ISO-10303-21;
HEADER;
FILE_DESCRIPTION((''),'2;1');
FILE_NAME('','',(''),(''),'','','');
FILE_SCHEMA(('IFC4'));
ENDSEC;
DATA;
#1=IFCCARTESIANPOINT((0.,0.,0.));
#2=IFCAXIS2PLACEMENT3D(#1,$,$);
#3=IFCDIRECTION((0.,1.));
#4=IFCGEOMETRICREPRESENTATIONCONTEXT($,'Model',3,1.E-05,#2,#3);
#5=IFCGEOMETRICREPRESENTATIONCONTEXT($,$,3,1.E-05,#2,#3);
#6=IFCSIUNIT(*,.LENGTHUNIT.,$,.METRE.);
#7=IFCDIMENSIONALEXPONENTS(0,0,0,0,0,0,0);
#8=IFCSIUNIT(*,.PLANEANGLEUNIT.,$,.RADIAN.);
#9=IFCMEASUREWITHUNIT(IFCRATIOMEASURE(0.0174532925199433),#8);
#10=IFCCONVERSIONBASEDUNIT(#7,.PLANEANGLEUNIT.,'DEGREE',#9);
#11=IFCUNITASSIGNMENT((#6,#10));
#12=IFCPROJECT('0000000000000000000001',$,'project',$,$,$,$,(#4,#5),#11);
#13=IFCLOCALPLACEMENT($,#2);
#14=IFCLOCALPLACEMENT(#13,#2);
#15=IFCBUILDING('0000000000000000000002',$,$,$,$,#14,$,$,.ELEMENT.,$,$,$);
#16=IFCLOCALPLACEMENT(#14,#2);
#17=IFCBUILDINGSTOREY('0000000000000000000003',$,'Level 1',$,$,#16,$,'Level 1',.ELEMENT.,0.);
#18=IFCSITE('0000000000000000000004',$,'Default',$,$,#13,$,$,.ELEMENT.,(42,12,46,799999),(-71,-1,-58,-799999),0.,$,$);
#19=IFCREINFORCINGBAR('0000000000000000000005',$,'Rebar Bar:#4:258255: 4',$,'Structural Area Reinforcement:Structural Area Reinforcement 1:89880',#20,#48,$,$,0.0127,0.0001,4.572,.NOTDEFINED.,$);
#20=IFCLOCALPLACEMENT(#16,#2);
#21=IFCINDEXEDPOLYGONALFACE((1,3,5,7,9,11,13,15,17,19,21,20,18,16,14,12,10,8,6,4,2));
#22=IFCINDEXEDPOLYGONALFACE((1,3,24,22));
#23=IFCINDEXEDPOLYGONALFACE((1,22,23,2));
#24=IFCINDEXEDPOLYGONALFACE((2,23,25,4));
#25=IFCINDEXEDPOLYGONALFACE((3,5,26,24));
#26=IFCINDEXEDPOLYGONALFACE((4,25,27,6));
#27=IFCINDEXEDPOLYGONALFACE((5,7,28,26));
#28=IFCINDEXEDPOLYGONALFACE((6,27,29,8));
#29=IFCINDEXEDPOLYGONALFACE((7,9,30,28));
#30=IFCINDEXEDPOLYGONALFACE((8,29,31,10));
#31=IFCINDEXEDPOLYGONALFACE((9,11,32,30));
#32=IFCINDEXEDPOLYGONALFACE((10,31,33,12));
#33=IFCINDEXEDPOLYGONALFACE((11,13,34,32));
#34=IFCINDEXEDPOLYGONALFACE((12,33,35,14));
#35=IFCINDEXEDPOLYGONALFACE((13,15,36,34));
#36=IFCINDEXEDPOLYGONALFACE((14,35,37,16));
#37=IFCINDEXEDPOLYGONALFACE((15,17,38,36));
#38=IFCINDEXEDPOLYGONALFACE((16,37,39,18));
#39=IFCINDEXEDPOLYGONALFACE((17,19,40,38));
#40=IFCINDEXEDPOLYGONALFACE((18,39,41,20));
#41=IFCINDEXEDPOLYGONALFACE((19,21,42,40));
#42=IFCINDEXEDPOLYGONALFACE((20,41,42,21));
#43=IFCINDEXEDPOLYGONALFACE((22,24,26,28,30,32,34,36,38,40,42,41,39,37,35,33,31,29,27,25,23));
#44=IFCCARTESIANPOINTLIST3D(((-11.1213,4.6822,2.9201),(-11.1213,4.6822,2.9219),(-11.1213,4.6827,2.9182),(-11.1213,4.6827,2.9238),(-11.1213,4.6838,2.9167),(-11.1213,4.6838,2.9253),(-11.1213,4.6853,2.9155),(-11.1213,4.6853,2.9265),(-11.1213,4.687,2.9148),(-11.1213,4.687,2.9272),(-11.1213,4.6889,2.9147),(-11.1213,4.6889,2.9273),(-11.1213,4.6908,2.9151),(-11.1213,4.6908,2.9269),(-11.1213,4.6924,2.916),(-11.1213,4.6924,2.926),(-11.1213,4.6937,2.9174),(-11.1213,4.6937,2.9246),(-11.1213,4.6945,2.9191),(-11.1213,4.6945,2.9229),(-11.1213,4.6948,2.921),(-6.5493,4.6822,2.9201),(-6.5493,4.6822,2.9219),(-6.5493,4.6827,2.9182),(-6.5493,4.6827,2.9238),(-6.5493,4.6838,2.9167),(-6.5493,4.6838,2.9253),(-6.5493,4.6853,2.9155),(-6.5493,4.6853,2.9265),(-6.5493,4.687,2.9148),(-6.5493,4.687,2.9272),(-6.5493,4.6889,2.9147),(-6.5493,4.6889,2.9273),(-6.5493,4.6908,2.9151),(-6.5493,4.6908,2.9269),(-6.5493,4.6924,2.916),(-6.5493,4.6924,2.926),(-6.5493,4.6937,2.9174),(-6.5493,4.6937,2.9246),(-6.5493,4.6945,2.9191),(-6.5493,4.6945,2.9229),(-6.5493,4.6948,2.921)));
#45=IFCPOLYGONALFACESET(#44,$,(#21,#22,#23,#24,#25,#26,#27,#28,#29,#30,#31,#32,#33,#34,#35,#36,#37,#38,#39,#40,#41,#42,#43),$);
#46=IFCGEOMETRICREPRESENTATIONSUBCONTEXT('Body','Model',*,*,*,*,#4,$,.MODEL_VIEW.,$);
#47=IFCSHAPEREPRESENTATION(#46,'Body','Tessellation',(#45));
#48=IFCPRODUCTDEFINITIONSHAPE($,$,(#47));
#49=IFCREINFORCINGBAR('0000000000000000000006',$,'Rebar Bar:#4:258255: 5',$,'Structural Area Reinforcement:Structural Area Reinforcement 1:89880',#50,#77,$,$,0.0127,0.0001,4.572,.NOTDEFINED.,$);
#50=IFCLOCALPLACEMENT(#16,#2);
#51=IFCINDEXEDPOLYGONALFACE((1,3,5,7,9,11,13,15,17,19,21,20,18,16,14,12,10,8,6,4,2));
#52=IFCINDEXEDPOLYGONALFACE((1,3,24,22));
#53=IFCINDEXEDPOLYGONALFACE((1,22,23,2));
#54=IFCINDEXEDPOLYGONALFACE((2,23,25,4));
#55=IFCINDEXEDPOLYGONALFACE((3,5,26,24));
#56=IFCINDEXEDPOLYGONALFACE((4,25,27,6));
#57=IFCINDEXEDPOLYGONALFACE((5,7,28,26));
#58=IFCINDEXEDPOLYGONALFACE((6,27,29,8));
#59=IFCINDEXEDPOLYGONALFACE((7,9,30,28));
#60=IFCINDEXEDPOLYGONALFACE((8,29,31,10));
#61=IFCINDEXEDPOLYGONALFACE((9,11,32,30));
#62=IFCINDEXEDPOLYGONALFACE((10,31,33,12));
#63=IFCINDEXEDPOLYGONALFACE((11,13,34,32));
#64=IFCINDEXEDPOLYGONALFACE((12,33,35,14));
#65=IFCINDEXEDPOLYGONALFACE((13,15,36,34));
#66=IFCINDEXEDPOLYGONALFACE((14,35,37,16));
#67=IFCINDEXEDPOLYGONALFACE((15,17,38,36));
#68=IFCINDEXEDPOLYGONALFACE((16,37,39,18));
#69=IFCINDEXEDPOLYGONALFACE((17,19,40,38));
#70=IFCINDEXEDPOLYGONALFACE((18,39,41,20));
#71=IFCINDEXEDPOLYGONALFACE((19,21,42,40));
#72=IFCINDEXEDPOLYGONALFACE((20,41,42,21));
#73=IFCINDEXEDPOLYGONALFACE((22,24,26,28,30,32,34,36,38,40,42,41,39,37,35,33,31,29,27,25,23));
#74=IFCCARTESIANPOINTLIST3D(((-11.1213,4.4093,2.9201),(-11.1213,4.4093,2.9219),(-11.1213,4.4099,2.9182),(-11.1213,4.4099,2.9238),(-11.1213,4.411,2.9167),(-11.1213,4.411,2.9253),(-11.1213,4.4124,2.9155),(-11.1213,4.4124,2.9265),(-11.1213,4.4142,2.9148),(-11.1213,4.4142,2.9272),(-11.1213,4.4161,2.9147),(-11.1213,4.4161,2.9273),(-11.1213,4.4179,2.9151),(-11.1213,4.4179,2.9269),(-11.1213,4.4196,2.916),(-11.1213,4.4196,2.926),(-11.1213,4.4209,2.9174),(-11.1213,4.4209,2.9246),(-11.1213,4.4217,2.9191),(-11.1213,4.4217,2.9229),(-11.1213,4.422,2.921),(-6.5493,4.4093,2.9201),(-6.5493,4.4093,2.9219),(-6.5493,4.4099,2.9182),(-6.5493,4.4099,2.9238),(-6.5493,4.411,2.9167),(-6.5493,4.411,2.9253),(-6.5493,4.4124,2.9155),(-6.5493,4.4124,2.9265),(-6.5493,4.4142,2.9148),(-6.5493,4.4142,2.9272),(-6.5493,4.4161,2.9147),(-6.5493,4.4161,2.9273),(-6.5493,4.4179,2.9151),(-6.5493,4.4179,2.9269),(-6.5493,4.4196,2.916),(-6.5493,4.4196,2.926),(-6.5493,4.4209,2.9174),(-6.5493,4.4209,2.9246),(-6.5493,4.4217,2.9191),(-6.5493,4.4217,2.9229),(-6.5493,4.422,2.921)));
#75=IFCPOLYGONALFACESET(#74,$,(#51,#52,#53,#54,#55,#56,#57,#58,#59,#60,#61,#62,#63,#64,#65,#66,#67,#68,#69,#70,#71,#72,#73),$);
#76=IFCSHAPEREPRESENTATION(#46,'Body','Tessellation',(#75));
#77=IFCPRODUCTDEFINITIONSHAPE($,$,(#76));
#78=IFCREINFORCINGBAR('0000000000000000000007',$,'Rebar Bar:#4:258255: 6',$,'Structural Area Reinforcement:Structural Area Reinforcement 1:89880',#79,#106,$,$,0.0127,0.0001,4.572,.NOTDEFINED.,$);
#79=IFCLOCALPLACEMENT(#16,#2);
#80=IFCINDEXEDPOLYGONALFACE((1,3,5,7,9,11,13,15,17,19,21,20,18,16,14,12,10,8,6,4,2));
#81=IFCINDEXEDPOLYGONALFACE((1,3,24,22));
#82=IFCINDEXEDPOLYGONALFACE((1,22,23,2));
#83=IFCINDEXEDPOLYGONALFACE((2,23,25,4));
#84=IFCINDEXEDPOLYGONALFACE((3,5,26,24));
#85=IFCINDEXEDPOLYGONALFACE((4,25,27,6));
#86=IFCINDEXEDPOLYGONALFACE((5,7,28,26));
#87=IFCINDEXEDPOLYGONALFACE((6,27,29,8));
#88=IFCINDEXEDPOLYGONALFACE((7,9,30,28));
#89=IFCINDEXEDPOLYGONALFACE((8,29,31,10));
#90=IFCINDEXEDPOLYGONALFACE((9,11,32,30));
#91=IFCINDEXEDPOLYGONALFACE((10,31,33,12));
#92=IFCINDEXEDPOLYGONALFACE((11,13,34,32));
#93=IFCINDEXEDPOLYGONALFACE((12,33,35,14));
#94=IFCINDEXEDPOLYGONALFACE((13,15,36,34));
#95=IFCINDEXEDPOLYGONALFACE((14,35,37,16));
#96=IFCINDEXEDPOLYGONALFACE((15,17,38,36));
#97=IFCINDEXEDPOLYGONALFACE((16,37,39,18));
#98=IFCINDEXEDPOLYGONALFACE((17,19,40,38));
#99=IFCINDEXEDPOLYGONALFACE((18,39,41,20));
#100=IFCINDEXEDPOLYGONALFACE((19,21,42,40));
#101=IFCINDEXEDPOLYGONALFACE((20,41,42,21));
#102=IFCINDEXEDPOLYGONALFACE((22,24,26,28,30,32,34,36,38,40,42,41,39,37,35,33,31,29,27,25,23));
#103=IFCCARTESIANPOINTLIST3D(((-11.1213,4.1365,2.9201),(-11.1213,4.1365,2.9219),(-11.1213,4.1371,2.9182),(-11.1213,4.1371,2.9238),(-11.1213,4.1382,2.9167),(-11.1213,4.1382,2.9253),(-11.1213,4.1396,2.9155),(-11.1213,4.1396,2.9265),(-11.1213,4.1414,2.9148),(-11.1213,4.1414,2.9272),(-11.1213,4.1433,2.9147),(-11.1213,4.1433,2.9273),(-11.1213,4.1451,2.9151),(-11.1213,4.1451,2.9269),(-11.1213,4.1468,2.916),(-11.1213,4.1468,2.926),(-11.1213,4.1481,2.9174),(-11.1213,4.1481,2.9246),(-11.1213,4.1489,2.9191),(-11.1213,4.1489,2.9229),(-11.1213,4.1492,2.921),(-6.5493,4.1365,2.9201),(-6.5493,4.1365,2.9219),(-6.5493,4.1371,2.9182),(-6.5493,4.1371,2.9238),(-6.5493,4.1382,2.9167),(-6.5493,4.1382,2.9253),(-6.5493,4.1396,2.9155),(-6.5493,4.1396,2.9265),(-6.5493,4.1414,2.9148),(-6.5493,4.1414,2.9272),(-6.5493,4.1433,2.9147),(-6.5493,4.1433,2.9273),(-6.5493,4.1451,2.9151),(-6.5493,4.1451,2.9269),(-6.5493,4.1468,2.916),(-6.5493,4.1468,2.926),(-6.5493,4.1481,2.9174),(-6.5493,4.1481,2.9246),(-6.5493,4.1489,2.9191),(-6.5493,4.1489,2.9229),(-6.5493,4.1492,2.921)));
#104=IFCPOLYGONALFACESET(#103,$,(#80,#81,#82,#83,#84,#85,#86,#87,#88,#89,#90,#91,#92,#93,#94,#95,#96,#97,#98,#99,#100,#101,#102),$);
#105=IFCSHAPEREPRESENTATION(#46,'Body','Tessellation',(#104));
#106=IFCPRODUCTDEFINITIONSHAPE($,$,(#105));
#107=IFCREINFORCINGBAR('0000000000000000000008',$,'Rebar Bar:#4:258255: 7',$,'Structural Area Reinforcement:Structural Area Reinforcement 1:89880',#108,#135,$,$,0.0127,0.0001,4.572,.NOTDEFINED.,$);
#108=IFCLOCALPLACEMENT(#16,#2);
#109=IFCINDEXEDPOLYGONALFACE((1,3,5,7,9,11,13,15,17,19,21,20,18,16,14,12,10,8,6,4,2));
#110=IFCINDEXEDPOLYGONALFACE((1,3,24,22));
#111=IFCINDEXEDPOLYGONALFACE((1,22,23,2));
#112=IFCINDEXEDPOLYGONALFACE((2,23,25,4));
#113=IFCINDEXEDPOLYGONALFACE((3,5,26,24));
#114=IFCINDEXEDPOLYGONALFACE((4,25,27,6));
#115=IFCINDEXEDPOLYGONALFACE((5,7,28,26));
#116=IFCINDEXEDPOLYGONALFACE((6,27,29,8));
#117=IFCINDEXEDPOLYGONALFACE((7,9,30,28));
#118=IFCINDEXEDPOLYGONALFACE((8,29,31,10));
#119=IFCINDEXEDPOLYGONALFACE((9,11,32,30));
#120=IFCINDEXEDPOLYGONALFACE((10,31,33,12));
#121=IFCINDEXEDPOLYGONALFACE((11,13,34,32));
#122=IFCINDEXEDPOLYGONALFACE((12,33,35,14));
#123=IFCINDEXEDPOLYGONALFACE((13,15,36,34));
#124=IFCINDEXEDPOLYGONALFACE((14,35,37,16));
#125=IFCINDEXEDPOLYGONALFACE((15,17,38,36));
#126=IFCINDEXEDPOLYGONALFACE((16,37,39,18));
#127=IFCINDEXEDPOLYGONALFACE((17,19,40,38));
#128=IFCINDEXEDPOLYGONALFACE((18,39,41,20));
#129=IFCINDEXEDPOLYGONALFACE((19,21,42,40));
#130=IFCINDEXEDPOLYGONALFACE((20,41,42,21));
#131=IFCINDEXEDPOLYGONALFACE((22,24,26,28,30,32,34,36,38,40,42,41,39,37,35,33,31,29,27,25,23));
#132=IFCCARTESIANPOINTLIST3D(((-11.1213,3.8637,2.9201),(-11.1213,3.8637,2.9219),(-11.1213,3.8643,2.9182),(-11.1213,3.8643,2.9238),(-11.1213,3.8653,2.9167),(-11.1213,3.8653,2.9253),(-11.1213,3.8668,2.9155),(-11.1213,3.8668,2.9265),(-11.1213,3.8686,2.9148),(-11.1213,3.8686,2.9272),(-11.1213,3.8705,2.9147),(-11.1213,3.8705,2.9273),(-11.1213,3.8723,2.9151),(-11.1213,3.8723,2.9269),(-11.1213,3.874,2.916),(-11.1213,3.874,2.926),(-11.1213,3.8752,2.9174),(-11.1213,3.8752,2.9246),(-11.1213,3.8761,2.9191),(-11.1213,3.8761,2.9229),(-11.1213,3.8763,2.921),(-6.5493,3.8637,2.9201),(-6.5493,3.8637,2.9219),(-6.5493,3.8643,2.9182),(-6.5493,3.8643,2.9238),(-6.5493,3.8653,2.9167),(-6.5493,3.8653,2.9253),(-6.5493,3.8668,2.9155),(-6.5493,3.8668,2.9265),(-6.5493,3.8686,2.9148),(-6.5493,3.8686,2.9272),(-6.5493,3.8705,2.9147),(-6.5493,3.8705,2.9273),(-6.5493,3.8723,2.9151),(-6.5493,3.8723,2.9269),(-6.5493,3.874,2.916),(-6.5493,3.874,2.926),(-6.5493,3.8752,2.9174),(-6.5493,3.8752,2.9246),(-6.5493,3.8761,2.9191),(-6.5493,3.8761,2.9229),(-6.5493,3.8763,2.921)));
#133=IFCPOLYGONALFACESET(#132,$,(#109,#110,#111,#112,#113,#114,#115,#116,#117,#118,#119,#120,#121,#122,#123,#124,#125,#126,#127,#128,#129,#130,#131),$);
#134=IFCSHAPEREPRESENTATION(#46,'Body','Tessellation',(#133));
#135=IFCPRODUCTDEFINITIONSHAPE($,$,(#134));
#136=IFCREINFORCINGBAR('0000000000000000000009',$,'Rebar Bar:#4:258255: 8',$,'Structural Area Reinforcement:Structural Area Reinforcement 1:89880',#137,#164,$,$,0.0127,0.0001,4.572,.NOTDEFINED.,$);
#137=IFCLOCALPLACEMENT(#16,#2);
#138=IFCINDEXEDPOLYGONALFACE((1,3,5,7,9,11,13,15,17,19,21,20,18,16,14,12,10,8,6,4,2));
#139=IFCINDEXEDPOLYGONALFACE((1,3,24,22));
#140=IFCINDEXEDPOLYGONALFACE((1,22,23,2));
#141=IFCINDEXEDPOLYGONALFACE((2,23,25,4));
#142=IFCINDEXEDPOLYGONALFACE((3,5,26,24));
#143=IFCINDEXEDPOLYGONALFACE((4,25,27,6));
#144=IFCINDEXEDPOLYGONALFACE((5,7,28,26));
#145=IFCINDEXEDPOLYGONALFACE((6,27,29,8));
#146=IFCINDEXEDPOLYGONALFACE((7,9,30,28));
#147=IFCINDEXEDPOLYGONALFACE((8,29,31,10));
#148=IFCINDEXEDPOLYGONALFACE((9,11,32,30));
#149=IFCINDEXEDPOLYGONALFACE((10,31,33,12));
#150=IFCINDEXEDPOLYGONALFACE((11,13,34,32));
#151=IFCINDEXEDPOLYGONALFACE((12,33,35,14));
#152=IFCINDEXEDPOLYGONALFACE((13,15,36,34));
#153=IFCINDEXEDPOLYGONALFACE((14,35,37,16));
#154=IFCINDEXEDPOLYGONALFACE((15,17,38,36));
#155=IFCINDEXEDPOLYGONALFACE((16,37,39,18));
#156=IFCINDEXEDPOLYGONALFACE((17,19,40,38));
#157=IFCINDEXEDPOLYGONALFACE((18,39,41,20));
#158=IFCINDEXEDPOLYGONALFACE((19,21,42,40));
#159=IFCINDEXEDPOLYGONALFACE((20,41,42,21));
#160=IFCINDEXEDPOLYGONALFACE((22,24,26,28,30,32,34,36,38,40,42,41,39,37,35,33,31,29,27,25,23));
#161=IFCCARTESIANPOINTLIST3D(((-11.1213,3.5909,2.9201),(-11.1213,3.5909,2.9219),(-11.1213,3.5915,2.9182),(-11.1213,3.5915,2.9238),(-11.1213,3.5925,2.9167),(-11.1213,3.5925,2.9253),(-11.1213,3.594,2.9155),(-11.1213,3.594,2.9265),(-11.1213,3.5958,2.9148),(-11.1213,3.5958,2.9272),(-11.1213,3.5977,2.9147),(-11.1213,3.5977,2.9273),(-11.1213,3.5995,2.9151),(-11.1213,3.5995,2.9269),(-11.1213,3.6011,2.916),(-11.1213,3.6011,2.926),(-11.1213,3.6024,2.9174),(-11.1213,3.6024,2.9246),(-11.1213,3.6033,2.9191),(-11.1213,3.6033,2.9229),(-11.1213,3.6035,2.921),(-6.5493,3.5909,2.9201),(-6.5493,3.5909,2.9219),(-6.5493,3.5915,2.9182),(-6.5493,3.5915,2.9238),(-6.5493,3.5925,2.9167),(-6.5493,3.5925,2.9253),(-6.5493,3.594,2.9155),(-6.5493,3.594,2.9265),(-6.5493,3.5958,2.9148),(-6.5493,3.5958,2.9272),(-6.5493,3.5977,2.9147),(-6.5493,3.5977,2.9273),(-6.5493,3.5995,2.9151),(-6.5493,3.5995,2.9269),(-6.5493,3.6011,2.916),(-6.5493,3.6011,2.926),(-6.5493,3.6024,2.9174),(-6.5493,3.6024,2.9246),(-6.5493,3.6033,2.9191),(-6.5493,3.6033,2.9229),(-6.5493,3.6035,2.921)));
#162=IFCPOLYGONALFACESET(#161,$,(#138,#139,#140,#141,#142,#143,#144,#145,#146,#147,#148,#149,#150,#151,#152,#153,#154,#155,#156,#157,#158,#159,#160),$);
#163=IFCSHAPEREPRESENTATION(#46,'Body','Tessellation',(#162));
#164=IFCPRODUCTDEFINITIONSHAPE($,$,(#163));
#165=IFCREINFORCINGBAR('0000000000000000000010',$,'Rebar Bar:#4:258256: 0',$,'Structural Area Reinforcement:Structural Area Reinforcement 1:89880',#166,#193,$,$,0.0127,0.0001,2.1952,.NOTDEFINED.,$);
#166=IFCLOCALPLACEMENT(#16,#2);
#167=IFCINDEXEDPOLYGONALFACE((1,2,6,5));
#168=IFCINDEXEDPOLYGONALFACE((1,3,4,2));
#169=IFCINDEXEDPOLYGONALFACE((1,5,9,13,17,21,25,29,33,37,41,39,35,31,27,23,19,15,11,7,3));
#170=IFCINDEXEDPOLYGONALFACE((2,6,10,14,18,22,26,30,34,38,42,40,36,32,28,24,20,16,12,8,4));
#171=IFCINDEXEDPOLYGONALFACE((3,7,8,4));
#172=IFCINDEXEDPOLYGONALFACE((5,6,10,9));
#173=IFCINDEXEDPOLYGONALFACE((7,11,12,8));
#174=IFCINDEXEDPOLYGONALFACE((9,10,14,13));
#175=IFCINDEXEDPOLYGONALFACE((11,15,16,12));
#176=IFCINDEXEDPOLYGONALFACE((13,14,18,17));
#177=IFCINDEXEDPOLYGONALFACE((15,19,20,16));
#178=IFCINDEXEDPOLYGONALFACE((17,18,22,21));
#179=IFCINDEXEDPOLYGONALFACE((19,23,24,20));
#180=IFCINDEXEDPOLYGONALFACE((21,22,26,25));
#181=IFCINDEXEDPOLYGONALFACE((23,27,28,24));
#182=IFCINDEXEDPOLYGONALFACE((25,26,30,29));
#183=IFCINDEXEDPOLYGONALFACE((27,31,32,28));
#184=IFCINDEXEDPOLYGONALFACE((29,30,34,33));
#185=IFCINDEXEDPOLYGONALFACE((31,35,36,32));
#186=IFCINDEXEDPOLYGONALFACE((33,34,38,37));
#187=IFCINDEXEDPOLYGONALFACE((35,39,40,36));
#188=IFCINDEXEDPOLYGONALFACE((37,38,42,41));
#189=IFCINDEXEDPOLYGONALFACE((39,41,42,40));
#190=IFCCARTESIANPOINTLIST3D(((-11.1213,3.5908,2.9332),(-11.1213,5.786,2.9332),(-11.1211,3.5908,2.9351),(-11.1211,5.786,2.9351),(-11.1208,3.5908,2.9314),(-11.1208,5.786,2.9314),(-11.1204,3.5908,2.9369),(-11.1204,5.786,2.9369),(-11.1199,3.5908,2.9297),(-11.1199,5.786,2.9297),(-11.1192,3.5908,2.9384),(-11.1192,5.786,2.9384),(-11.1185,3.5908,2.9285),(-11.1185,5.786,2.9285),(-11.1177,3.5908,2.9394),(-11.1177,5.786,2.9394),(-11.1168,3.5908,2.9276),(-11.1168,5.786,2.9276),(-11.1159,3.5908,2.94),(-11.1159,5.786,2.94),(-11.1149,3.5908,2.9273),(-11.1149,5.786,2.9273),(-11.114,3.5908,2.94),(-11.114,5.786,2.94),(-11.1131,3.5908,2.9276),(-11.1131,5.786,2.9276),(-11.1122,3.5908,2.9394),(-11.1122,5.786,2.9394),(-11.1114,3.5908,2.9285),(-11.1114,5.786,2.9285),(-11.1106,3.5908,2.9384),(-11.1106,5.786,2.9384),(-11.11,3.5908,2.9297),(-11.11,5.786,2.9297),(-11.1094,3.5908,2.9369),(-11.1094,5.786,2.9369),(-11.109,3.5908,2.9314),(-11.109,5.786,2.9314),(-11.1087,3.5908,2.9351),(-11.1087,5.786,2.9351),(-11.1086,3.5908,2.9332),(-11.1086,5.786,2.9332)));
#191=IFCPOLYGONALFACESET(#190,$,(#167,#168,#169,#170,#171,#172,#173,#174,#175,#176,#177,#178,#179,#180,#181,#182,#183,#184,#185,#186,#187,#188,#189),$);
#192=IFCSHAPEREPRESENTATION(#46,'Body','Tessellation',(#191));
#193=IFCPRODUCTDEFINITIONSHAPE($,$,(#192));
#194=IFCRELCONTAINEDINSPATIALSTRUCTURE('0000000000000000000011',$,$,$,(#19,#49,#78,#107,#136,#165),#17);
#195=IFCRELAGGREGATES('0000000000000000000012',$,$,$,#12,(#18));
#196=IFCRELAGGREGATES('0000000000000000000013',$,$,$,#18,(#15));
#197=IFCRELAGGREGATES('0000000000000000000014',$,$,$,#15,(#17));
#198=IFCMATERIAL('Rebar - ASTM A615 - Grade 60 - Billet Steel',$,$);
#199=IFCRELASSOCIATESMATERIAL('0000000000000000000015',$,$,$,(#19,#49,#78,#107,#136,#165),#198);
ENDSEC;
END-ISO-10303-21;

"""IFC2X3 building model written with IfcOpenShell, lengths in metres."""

from ifc_helpers import new_model, entity, si_unit, converted_unit, direction, origin, place, context, subcontext, project, spatial, material, element, save


model = new_model("IFC2X3")

# Units and contexts
model_context = context("Model", 3, precision=1e-05, world=origin(), true_north=direction((0.0, 1.0)))
context_of_model = context(None, 3, precision=1e-05, world=origin(), true_north=direction((0.0, 1.0)))
body_context = subcontext(model_context, "Body", "Model", "MODEL_VIEW")
ifc_project = project(units=[si_unit("LENGTHUNIT", "METRE"), converted_unit("PLANEANGLEUNIT", "DEGREE", entity("IfcRatioMeasure", 0.0174532925199433), si_unit("PLANEANGLEUNIT", "RADIAN"), dimensions=[0, 0, 0, 0, 0, 0, 0])], contexts=[model_context, context_of_model])

# Site, building, storey
site_placement = place(None, origin())
site = spatial("IfcSite", under=ifc_project, at=site_placement, Name="Default", CompositionType="ELEMENT", RefLatitude=(42, 12, 46, 799999), RefLongitude=(-71, -1, -58, -799999), RefElevation=0.0)
building_placement = place(site_placement, origin())
building = spatial("IfcBuilding", under=site, at=building_placement, CompositionType="ELEMENT")
storey_placement = place(building_placement, origin())
storey = spatial("IfcBuildingStorey", under=building, at=storey_placement, Name="Level 1", LongName="Level 1", CompositionType="ELEMENT", Elevation=0.0)

# Shared definitions
ifc_material_1 = material(Name="Rebar - ASTM A615 - Grade 60 - Billet Steel")

# Reinforcing bars
reinforcing_bar_1_placement = place(storey_placement, origin())
element("IfcReinforcingBar", 1, at=reinforcing_bar_1_placement, inside=storey, material=ifc_material_1, Name="Rebar Bar:#4:258255: 4", ObjectType="Structural Area Reinforcement:Structural Area Reinforcement 1:89880", BarLength=4.572, BarRole="NOTDEFINED", CrossSectionArea=0.0001, NominalDiameter=0.0127, context=body_context, shape_type="AdvancedSweptSolid", body=[
    entity("IfcSweptDiskSolid", entity("IfcCompositeCurve", [entity("IfcCompositeCurveSegment", "CONTINUOUS", True, entity("IfcPolyline", [entity("IfcCartesianPoint", [-11.1213, 4.6884, 2.921]), entity("IfcCartesianPoint", [-6.5493, 4.6884, 2.921])]))], False), 0.0063, None, 0.0, 1.0),
])
reinforcing_bar_2_placement = place(storey_placement, origin())
element("IfcReinforcingBar", 2, at=reinforcing_bar_2_placement, inside=storey, material=ifc_material_1, Name="Rebar Bar:#4:258255: 5", ObjectType="Structural Area Reinforcement:Structural Area Reinforcement 1:89880", BarLength=4.572, BarRole="NOTDEFINED", CrossSectionArea=0.0001, NominalDiameter=0.0127, context=body_context, shape_type="AdvancedSweptSolid", body=[
    entity("IfcSweptDiskSolid", entity("IfcCompositeCurve", [entity("IfcCompositeCurveSegment", "CONTINUOUS", True, entity("IfcPolyline", [entity("IfcCartesianPoint", [-11.1213, 4.4156, 2.921]), entity("IfcCartesianPoint", [-6.5493, 4.4156, 2.921])]))], False), 0.0063, None, 0.0, 1.0),
])
reinforcing_bar_3_placement = place(storey_placement, origin())
element("IfcReinforcingBar", 3, at=reinforcing_bar_3_placement, inside=storey, material=ifc_material_1, Name="Rebar Bar:#4:258255: 6", ObjectType="Structural Area Reinforcement:Structural Area Reinforcement 1:89880", BarLength=4.572, BarRole="NOTDEFINED", CrossSectionArea=0.0001, NominalDiameter=0.0127, context=body_context, shape_type="AdvancedSweptSolid", body=[
    entity("IfcSweptDiskSolid", entity("IfcCompositeCurve", [entity("IfcCompositeCurveSegment", "CONTINUOUS", True, entity("IfcPolyline", [entity("IfcCartesianPoint", [-11.1213, 4.1428, 2.921]), entity("IfcCartesianPoint", [-6.5493, 4.1428, 2.921])]))], False), 0.0063, None, 0.0, 1.0),
])
reinforcing_bar_4_placement = place(storey_placement, origin())
element("IfcReinforcingBar", 4, at=reinforcing_bar_4_placement, inside=storey, material=ifc_material_1, Name="Rebar Bar:#4:258255: 7", ObjectType="Structural Area Reinforcement:Structural Area Reinforcement 1:89880", BarLength=4.572, BarRole="NOTDEFINED", CrossSectionArea=0.0001, NominalDiameter=0.0127, context=body_context, shape_type="AdvancedSweptSolid", body=[
    entity("IfcSweptDiskSolid", entity("IfcCompositeCurve", [entity("IfcCompositeCurveSegment", "CONTINUOUS", True, entity("IfcPolyline", [entity("IfcCartesianPoint", [-11.1213, 3.87, 2.921]), entity("IfcCartesianPoint", [-6.5493, 3.87, 2.921])]))], False), 0.0063, None, 0.0, 1.0),
])
reinforcing_bar_5_placement = place(storey_placement, origin())
element("IfcReinforcingBar", 5, at=reinforcing_bar_5_placement, inside=storey, material=ifc_material_1, Name="Rebar Bar:#4:258255: 8", ObjectType="Structural Area Reinforcement:Structural Area Reinforcement 1:89880", BarLength=4.572, BarRole="NOTDEFINED", CrossSectionArea=0.0001, NominalDiameter=0.0127, context=body_context, shape_type="AdvancedSweptSolid", body=[
    entity("IfcSweptDiskSolid", entity("IfcCompositeCurve", [entity("IfcCompositeCurveSegment", "CONTINUOUS", True, entity("IfcPolyline", [entity("IfcCartesianPoint", [-11.1213, 3.5972, 2.921]), entity("IfcCartesianPoint", [-6.5493, 3.5972, 2.921])]))], False), 0.0063, None, 0.0, 1.0),
])
reinforcing_bar_6_placement = place(storey_placement, origin())
element("IfcReinforcingBar", 6, at=reinforcing_bar_6_placement, inside=storey, material=ifc_material_1, Name="Rebar Bar:#4:258256: 0", ObjectType="Structural Area Reinforcement:Structural Area Reinforcement 1:89880", BarLength=2.1952, BarRole="NOTDEFINED", CrossSectionArea=0.0001, NominalDiameter=0.0127, context=body_context, shape_type="AdvancedSweptSolid", body=[
    entity("IfcSweptDiskSolid", entity("IfcCompositeCurve", [entity("IfcCompositeCurveSegment", "CONTINUOUS", True, entity("IfcPolyline", [entity("IfcCartesianPoint", [-11.1149, 5.786, 2.9337]), entity("IfcCartesianPoint", [-11.1149, 3.5908, 2.9337])]))], False), 0.0063, None, 0.0, 1.0),
])

save(model, "model.ifc")
